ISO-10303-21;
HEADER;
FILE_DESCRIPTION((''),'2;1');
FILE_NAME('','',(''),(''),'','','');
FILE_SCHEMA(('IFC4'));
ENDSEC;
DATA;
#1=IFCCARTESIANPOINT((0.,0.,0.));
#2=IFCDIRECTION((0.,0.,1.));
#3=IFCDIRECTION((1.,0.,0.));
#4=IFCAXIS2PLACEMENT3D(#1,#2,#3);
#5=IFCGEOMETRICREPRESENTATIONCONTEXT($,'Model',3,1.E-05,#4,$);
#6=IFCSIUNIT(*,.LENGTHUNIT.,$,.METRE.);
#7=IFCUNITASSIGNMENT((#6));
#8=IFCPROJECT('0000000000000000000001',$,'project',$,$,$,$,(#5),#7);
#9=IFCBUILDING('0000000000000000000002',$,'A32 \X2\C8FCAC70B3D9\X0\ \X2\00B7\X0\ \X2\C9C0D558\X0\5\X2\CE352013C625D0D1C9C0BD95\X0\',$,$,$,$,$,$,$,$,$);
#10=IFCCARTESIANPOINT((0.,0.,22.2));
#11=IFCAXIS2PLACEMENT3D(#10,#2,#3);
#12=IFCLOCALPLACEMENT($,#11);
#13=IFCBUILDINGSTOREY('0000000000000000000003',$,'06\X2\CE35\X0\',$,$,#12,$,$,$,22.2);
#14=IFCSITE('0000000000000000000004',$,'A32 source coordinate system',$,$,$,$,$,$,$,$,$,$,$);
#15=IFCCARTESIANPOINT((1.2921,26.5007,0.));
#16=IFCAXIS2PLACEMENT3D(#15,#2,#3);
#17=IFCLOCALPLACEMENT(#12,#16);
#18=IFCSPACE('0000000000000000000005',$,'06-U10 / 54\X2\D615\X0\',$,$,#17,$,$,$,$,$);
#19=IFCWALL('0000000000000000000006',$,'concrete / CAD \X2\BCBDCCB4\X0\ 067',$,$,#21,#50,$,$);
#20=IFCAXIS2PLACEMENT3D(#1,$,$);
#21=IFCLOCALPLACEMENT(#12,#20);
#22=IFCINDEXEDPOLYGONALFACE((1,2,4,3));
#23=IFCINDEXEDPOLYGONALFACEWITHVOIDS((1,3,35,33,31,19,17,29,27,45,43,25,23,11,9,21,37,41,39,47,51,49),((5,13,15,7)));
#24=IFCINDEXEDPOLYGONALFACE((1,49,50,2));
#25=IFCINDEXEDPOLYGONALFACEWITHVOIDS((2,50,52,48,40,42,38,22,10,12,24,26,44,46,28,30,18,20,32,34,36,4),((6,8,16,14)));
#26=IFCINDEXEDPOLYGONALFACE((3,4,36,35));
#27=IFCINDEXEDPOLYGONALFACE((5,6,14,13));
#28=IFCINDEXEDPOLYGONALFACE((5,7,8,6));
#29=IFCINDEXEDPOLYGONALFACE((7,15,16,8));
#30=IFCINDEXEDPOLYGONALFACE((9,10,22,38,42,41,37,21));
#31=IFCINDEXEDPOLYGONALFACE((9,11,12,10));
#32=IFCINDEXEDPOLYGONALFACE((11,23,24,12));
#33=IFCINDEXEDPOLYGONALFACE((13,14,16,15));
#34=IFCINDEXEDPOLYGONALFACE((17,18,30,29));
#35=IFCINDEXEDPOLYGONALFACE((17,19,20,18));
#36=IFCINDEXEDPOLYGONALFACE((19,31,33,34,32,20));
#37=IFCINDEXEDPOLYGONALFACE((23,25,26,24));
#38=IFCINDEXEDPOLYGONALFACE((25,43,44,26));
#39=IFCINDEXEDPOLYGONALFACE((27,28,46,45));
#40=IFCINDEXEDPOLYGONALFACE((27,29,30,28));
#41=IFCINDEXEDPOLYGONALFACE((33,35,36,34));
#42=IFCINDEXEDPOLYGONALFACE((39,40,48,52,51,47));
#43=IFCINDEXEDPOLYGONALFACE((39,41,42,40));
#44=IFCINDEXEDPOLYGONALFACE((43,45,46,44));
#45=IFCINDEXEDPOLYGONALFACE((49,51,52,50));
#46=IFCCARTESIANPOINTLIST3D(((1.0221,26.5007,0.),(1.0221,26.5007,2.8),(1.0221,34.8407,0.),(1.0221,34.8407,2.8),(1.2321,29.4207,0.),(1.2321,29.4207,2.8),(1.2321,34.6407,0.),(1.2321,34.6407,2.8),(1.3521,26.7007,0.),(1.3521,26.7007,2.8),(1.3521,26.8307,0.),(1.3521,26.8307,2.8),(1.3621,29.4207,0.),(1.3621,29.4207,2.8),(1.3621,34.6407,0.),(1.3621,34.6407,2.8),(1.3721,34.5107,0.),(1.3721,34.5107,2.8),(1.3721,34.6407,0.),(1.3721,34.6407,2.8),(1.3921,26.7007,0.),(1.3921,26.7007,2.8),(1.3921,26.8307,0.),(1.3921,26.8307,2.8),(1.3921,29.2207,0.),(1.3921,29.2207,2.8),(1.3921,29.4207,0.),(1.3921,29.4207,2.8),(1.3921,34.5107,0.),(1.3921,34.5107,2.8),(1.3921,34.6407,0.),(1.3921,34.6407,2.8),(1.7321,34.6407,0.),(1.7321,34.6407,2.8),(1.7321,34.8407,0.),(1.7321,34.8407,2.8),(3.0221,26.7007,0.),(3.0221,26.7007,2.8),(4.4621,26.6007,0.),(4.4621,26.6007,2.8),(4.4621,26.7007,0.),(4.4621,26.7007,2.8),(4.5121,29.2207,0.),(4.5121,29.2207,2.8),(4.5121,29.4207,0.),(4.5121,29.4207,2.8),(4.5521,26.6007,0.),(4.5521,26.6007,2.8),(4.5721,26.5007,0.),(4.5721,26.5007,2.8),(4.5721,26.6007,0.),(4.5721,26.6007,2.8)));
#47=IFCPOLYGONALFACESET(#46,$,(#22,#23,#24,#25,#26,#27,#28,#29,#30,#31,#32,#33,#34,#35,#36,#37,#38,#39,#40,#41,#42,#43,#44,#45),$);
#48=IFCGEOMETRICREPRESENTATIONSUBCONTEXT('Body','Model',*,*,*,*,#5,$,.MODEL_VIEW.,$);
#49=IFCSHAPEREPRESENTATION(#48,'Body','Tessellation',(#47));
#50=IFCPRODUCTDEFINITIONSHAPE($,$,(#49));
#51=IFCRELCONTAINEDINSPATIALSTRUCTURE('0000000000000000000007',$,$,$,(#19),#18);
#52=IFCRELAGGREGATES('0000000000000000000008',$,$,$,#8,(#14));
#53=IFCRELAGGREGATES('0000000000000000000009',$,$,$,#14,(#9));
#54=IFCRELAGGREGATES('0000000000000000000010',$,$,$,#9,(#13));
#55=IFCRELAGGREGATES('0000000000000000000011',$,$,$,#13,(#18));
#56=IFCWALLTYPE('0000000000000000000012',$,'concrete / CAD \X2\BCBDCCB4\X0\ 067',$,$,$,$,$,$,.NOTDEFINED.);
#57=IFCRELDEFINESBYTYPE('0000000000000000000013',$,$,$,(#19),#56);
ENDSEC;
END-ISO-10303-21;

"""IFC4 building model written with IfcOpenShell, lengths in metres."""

from ifc_helpers import new_model, si_unit, frame, origin, origin_with_axes, place, context, subcontext, project, spatial, polyline, outline, extrude, source, transform, mapped, type_object, type_shapes, element, save


model = new_model("IFC4")

# Units and contexts
model_context = context("Model", 3, precision=1e-05, world=origin_with_axes())
body_context = subcontext(model_context, "Body", "Model", "MODEL_VIEW")
ifc_project = project(units=[si_unit("LENGTHUNIT", "METRE")], contexts=[model_context])

# Site, building, storey, space
site = spatial("IfcSite", under=ifc_project, Name="A32 source coordinate system")
building = spatial("IfcBuilding", under=site, Name="A32 주거동 · 지하5층–옥탑지붕")
storey_placement = place(None, frame((0.0, 0.0, 22.2), z_axis=(0.0, 0.0, 1.0), x_axis=(1.0, 0.0, 0.0)))
storey = spatial("IfcBuildingStorey", under=building, at=storey_placement, Name="06층", Elevation=22.2)
space_placement = place(storey_placement, frame((1.2921, 26.5007, 0.0), z_axis=(0.0, 0.0, 1.0), x_axis=(1.0, 0.0, 0.0)))
space = spatial("IfcSpace", under=storey, at=space_placement, Name="06-U10 / 54형")

# Wall
wall_type_1 = type_object("IfcWallType", Name="concrete / CAD 벽체 067", PredefinedType="NOTDEFINED")
shared_shape_1 = source(origin(), body_context, "Body", "SweptSolid", [
    extrude(outline(polyline([(0.1, 0.2), (1.73, 0.2), (3.17, 0.2), (3.17, 0.1), (3.26, 0.1), (3.28, 0.1), (3.28, 0.0), (-0.27, 0.0), (-0.27, 8.34), (0.44, 8.34), (0.44, 8.14), (0.1, 8.14), (0.08, 8.14), (0.08, 8.01), (0.1, 8.01), (0.1, 2.92), (3.22, 2.92), (3.22, 2.72), (0.1, 2.72), (0.1, 0.33), (0.06, 0.33), (0.06, 0.2), (0.1, 0.2)]), holes=[polyline([(-0.06, 8.14), (-0.06, 2.92), (0.07, 2.92), (0.07, 8.14), (-0.06, 8.14)])]), origin(), (0.0, 0.0, 1.0), 2.8),
])
type_shapes(wall_type_1, [shared_shape_1])
wall_1_placement = place(space_placement, origin_with_axes())
element("IfcWall", 1, at=wall_1_placement, inside=space, type_object=wall_type_1, Name="concrete / CAD 벽체 067", context=body_context, shape_type="MappedRepresentation", body=[
    mapped(shared_shape_1, transform((0.0, 0.0, 0.0), scale=1.0)),
])

save(model, "model.ifc")
